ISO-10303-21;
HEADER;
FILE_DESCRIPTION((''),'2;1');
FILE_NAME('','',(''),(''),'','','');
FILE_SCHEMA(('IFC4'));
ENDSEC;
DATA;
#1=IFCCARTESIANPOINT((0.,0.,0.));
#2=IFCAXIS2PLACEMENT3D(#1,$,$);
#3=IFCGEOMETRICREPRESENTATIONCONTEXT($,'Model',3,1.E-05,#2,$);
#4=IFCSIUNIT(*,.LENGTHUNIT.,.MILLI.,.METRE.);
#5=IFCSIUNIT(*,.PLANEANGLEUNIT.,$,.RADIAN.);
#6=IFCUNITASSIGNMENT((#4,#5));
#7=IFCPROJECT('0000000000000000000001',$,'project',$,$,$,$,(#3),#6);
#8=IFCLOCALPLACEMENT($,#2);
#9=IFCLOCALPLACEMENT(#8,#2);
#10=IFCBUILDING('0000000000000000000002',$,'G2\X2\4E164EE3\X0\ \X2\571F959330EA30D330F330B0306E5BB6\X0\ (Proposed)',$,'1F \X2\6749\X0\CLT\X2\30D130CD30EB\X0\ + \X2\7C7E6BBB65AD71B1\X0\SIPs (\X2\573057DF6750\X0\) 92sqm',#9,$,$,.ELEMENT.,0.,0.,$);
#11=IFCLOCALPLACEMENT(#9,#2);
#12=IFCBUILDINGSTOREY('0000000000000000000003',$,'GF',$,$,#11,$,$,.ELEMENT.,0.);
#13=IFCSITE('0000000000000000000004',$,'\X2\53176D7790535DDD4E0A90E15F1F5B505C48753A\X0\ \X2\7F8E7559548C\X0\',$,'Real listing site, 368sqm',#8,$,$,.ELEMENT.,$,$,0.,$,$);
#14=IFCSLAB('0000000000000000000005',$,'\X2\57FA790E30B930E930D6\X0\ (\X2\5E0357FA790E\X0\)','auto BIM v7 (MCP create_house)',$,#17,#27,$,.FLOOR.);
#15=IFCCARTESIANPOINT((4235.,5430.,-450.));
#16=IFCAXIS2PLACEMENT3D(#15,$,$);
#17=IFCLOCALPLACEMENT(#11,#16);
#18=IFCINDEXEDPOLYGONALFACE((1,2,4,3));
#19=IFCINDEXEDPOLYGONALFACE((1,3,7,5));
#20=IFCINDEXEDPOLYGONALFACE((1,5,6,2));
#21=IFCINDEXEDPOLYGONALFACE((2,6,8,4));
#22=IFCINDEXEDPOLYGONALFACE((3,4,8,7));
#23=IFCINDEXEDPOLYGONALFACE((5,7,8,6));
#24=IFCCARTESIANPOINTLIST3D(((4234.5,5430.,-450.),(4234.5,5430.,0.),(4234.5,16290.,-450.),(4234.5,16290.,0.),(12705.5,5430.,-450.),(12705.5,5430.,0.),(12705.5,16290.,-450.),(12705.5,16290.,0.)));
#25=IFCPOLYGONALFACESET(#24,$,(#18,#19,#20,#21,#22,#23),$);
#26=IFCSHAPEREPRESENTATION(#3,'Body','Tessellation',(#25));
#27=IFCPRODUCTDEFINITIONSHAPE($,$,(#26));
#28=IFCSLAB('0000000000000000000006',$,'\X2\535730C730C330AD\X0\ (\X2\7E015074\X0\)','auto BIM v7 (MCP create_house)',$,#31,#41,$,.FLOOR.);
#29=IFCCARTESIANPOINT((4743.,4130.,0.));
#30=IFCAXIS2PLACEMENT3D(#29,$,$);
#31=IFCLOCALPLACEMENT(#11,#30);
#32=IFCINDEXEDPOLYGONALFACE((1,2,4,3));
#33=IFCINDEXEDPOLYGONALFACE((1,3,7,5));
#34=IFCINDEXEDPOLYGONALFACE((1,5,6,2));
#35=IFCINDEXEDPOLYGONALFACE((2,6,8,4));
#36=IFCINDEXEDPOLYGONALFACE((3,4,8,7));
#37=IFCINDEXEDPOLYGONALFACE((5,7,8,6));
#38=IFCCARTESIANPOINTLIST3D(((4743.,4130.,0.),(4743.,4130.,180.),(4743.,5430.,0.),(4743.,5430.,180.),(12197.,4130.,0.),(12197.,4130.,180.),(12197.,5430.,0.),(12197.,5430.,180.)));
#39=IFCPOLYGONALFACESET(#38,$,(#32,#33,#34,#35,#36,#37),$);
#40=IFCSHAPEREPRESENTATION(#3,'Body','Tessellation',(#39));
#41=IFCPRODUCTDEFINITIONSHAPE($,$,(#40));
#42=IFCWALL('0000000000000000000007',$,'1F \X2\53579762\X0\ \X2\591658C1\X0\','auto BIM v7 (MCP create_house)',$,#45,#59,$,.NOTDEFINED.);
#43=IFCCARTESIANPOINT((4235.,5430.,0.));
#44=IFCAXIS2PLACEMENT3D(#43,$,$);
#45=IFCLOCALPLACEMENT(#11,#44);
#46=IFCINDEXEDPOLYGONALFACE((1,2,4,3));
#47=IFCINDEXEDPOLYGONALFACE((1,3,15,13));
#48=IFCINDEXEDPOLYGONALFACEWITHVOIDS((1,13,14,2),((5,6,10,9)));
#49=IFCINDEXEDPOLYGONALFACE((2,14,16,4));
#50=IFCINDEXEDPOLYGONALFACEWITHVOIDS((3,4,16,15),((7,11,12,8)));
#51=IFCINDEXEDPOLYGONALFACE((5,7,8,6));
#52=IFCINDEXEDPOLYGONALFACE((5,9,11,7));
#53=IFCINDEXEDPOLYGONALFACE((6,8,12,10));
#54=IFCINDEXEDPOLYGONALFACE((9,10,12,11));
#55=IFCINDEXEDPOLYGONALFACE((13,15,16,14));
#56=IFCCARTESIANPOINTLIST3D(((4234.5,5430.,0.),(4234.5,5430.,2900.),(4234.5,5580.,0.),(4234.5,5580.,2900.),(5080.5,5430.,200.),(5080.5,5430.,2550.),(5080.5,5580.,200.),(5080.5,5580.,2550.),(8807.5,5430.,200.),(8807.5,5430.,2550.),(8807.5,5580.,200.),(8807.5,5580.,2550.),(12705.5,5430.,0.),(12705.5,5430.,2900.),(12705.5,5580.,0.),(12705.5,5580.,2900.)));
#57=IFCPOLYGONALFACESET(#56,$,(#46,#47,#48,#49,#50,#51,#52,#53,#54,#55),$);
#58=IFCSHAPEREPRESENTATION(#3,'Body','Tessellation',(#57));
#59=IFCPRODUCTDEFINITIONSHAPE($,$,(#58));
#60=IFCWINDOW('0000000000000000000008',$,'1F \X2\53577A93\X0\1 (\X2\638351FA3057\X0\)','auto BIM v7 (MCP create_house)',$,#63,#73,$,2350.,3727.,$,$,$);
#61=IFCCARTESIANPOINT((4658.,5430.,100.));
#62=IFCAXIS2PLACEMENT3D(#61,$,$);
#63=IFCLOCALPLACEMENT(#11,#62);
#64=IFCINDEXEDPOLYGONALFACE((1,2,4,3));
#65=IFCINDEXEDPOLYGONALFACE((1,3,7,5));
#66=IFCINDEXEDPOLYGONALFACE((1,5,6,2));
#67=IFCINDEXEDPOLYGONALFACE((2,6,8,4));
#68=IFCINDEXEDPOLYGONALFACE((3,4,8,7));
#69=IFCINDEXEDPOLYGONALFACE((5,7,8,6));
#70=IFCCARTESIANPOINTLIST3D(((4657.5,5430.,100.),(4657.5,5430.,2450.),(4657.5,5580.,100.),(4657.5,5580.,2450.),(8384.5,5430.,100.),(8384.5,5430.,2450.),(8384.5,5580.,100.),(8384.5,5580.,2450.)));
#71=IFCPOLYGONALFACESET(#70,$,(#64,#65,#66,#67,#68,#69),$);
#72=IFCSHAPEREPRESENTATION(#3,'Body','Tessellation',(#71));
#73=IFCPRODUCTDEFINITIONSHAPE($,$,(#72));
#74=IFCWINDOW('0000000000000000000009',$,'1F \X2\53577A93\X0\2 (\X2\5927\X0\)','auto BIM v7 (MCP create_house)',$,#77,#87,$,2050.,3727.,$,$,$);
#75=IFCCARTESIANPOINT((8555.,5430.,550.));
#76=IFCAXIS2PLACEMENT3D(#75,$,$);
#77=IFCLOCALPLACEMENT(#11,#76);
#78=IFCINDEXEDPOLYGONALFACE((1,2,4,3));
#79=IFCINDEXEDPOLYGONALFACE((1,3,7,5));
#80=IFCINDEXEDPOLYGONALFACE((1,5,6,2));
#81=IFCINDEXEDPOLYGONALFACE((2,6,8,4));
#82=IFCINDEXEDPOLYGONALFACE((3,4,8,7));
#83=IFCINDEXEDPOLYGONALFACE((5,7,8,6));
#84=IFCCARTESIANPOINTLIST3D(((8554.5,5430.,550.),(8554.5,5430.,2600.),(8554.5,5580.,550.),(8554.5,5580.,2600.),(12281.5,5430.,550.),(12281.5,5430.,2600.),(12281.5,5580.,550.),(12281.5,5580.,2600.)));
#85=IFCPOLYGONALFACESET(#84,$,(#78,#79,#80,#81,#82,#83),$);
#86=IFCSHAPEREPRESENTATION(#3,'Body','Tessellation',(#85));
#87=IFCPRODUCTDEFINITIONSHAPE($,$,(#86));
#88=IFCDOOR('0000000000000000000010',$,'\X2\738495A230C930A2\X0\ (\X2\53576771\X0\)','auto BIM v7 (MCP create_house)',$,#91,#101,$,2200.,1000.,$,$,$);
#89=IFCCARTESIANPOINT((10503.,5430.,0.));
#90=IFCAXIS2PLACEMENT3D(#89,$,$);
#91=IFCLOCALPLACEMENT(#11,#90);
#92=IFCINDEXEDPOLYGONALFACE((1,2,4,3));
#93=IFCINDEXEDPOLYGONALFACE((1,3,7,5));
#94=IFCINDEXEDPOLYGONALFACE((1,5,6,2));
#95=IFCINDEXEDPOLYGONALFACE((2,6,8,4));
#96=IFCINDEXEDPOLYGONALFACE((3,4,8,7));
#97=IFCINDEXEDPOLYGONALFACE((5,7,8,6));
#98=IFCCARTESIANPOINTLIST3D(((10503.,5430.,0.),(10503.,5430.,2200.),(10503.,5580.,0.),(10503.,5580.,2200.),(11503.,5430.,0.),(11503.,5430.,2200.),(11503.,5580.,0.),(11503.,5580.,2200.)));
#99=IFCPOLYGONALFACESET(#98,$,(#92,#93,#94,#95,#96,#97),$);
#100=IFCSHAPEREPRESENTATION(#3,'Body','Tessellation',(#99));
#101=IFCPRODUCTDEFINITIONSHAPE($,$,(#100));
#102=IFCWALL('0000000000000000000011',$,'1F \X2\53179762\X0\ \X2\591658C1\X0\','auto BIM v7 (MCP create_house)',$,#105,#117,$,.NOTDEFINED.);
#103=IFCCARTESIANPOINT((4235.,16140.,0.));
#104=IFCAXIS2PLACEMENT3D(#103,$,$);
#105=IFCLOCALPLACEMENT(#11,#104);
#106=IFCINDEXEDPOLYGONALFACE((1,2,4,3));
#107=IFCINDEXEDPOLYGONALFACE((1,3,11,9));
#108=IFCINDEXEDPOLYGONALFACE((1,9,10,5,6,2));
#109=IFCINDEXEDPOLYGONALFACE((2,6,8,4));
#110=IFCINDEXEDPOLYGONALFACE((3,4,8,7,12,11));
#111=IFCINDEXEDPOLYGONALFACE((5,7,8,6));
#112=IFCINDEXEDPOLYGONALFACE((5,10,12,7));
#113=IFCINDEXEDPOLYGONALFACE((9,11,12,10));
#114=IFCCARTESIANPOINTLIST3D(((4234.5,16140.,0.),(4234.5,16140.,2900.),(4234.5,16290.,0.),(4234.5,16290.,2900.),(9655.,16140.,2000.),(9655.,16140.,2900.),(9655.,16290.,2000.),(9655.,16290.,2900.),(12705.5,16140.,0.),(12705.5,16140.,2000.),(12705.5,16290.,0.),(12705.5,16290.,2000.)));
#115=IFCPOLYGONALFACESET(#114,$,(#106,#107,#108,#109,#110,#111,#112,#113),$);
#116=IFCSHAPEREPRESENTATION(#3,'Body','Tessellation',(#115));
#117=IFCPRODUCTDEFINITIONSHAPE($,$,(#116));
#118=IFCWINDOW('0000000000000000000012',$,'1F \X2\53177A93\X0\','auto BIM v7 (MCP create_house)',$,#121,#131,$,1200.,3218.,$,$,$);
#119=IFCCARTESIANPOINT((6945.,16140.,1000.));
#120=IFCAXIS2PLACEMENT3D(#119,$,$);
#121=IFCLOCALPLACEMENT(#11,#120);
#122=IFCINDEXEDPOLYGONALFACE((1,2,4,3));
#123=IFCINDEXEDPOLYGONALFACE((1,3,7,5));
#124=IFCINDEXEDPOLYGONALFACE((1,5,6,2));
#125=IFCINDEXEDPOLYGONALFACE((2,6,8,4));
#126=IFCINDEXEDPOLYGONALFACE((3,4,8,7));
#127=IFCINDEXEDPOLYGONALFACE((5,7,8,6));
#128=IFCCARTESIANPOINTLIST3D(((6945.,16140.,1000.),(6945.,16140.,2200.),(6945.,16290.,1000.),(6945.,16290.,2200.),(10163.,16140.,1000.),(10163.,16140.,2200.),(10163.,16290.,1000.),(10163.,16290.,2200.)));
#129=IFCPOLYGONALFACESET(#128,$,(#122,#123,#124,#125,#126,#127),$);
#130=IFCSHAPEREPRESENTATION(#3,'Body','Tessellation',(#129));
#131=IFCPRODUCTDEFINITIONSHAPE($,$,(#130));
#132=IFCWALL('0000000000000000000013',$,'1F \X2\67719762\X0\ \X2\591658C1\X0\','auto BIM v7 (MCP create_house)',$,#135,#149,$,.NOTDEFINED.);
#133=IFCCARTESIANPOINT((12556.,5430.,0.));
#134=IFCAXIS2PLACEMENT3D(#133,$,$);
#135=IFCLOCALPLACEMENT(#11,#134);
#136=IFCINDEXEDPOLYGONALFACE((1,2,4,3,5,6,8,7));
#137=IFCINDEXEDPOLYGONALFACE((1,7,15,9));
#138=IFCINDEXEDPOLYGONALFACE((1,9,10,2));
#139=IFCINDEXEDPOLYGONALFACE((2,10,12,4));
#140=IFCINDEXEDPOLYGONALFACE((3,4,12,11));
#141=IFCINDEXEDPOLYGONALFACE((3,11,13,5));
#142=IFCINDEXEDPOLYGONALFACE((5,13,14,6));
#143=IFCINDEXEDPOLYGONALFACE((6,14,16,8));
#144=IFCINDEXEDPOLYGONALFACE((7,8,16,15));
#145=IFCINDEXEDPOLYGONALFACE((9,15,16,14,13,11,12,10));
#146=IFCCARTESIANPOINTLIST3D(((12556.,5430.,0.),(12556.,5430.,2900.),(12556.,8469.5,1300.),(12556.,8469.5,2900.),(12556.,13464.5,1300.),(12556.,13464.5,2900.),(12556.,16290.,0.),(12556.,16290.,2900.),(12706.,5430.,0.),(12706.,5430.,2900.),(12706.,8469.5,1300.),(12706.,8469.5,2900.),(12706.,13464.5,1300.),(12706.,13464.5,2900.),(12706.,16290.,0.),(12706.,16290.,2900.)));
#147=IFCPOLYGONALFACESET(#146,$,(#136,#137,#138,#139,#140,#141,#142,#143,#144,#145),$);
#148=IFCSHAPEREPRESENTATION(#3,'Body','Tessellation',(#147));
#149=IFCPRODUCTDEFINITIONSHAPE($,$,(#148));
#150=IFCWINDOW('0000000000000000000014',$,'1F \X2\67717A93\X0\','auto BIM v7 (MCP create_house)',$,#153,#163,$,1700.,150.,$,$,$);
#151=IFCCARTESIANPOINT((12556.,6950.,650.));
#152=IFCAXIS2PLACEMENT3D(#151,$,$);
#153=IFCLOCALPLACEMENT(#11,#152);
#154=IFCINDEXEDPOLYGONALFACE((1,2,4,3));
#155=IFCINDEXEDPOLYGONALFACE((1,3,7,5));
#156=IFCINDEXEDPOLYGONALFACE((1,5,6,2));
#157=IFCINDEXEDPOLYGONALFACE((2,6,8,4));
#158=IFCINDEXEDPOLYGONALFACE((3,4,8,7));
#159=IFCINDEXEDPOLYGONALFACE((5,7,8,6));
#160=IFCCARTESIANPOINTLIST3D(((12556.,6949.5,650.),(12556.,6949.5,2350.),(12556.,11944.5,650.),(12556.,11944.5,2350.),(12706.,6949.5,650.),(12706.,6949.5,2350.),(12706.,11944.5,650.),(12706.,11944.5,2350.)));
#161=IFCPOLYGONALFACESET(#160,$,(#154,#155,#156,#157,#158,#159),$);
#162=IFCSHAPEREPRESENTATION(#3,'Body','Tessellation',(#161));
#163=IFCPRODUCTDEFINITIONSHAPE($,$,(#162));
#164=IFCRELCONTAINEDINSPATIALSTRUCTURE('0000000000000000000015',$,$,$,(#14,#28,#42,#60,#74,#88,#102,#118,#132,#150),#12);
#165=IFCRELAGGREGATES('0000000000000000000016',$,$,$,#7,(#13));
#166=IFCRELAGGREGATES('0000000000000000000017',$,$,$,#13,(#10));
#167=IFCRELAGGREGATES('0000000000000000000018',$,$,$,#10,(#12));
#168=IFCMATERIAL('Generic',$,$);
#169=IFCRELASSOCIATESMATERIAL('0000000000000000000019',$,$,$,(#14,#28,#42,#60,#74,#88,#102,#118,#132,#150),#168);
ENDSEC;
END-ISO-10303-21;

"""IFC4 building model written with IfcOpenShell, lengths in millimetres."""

from ifc_helpers import new_model, si_unit, frame, frame_2d, origin, place, context, project, spatial, rectangle, extrude, material, element, fill, save


model = new_model("IFC4")

# Units and contexts
model_context = context("Model", 3, precision=1e-05, world=origin())
ifc_project = project(units=[si_unit("LENGTHUNIT", "METRE", prefix="MILLI"), si_unit("PLANEANGLEUNIT", "RADIAN")], contexts=[model_context])

# Site, building, storey
site_placement = place(None, origin())
site = spatial("IfcSite", under=ifc_project, at=site_placement, Name="北海道川上郡弟子屈町 美留和", ObjectType="Real listing site, 368sqm", CompositionType="ELEMENT", RefElevation=0.0)
building_placement = place(site_placement, origin())
building = spatial("IfcBuilding", under=site, at=building_placement, Name="G2世代 土間リビングの家 (Proposed)", ObjectType="1F 杉CLTパネル + 籾殻断熱SIPs (地域材) 92sqm", CompositionType="ELEMENT", ElevationOfRefHeight=0.0, ElevationOfTerrain=0.0)
storey_placement = place(building_placement, origin())
storey = spatial("IfcBuildingStorey", under=building, at=storey_placement, Name="GF", CompositionType="ELEMENT", Elevation=0.0)

# Slabs
ifc_material = material(Name="Generic")
slab_1_placement = place(storey_placement, frame((4235.0, 5430.0, -450.0)))
element("IfcSlab", 1, at=slab_1_placement, inside=storey, material=ifc_material, Name="基礎スラブ (布基礎)", Description="auto BIM v7 (MCP create_house)", PredefinedType="FLOOR", context=model_context, shape_type="SweptSolid", body=[
    extrude(rectangle(XDim=8471.0, YDim=10860.0, at=frame_2d((4235.0, 5430.0))), frame((4235.0, 5430.0, -450.0)), (0.0, 0.0, 1.0), 450.0),
])
slab_2_placement = place(storey_placement, frame((4743.0, 4130.0, 0.0)))
element("IfcSlab", 2, at=slab_2_placement, inside=storey, material=ifc_material, Name="南デッキ (縁側)", Description="auto BIM v7 (MCP create_house)", PredefinedType="FLOOR", context=model_context, shape_type="SweptSolid", body=[
    extrude(rectangle(XDim=7454.0, YDim=1300.0, at=frame_2d((3727.0, 650.0))), frame((4743.0, 4130.0, 0.0)), (0.0, 0.0, 1.0), 180.0),
])

# Wall, openings, windows, door
wall_1_placement = place(storey_placement, frame((4235.0, 5430.0, 0.0)))
wall_1 = element("IfcWall", 3, at=wall_1_placement, inside=storey, material=ifc_material, Name="1F 南面 外壁", Description="auto BIM v7 (MCP create_house)", PredefinedType="NOTDEFINED", context=model_context, shape_type="SweptSolid", body=[
    extrude(rectangle(XDim=8471.0, YDim=150.0, at=frame_2d((4235.0, 75.0))), frame((4235.0, 5430.0, 0.0)), (0.0, 0.0, 1.0), 2900.0),
])
opening_1_placement = place(storey_placement, frame((4658.0, 5430.0, 100.0)))
opening_1 = element("IfcOpeningElement", 4, at=opening_1_placement, cuts=wall_1, PredefinedType="NOTDEFINED", context=model_context, shape_type="SweptSolid", body=[
    extrude(rectangle(XDim=3727.0, YDim=150.0, at=frame_2d((1863.0, 75.0))), frame((4658.0, 5430.0, 100.0)), (0.0, 0.0, 1.0), 2350.0),
])
opening_2_placement = place(storey_placement, frame((8555.0, 5430.0, 550.0)))
opening_2 = element("IfcOpeningElement", 5, at=opening_2_placement, cuts=wall_1, PredefinedType="NOTDEFINED", context=model_context, shape_type="SweptSolid", body=[
    extrude(rectangle(XDim=3727.0, YDim=150.0, at=frame_2d((1863.0, 75.0))), frame((8555.0, 5430.0, 550.0)), (0.0, 0.0, 1.0), 2050.0),
])
opening_3_placement = place(storey_placement, frame((10503.0, 5430.0, 0.0)))
opening_3 = element("IfcOpeningElement", 6, at=opening_3_placement, cuts=wall_1, PredefinedType="NOTDEFINED", context=model_context, shape_type="SweptSolid", body=[
    extrude(rectangle(XDim=1000.0, YDim=150.0, at=frame_2d((500.0, 75.0))), frame((10503.0, 5430.0, 0.0)), (0.0, 0.0, 1.0), 2200.0),
])
window_1_placement = place(storey_placement, frame((4658.0, 5430.0, 100.0)))
window_1 = element("IfcWindow", 7, at=window_1_placement, inside=storey, material=ifc_material, Name="1F 南窓1 (掃出し)", Description="auto BIM v7 (MCP create_house)", OverallHeight=2350.0, OverallWidth=3727.0, context=model_context, shape_type="SweptSolid", body=[
    extrude(rectangle(XDim=3727.0, YDim=150.0, at=frame_2d((1863.0, 75.0))), frame((4658.0, 5430.0, 100.0)), (0.0, 0.0, 1.0), 2350.0),
])
fill(opening_1, window_1)
window_2_placement = place(storey_placement, frame((8555.0, 5430.0, 550.0)))
window_2 = element("IfcWindow", 8, at=window_2_placement, inside=storey, material=ifc_material, Name="1F 南窓2 (大)", Description="auto BIM v7 (MCP create_house)", OverallHeight=2050.0, OverallWidth=3727.0, context=model_context, shape_type="SweptSolid", body=[
    extrude(rectangle(XDim=3727.0, YDim=150.0, at=frame_2d((1863.0, 75.0))), frame((8555.0, 5430.0, 550.0)), (0.0, 0.0, 1.0), 2050.0),
])
fill(opening_2, window_2)
door_placement = place(storey_placement, frame((10503.0, 5430.0, 0.0)))
door = element("IfcDoor", 9, at=door_placement, inside=storey, material=ifc_material, Name="玄関ドア (南東)", Description="auto BIM v7 (MCP create_house)", OverallHeight=2200.0, OverallWidth=1000.0, context=model_context, shape_type="SweptSolid", body=[
    extrude(rectangle(XDim=1000.0, YDim=150.0, at=frame_2d((500.0, 75.0))), frame((10503.0, 5430.0, 0.0)), (0.0, 0.0, 1.0), 2200.0),
])
fill(opening_3, door)

# Walls, openings, windows
wall_2_placement = place(storey_placement, frame((4235.0, 16140.0, 0.0)))
wall_2 = element("IfcWall", 10, at=wall_2_placement, inside=storey, material=ifc_material, Name="1F 北面 外壁", Description="auto BIM v7 (MCP create_house)", PredefinedType="NOTDEFINED", context=model_context, shape_type="SweptSolid", body=[
    extrude(rectangle(XDim=8471.0, YDim=150.0, at=frame_2d((4235.0, 75.0))), frame((4235.0, 16140.0, 0.0)), (0.0, 0.0, 1.0), 2900.0),
])
opening_4_placement = place(storey_placement, frame((6945.0, 16140.0, 1000.0)))
opening_4 = element("IfcOpeningElement", 11, at=opening_4_placement, cuts=wall_2, PredefinedType="NOTDEFINED", context=model_context, shape_type="SweptSolid", body=[
    extrude(rectangle(XDim=3218.0, YDim=150.0, at=frame_2d((1609.0, 75.0))), frame((6945.0, 16140.0, 1000.0)), (0.0, 0.0, 1.0), 1200.0),
])
window_3_placement = place(storey_placement, frame((6945.0, 16140.0, 1000.0)))
window_3 = element("IfcWindow", 12, at=window_3_placement, inside=storey, material=ifc_material, Name="1F 北窓", Description="auto BIM v7 (MCP create_house)", OverallHeight=1200.0, OverallWidth=3218.0, context=model_context, shape_type="SweptSolid", body=[
    extrude(rectangle(XDim=3218.0, YDim=150.0, at=frame_2d((1609.0, 75.0))), frame((6945.0, 16140.0, 1000.0)), (0.0, 0.0, 1.0), 1200.0),
])
fill(opening_4, window_3)
wall_3_placement = place(storey_placement, frame((12556.0, 5430.0, 0.0)))
wall_3 = element("IfcWall", 13, at=wall_3_placement, inside=storey, material=ifc_material, Name="1F 東面 外壁", Description="auto BIM v7 (MCP create_house)", PredefinedType="NOTDEFINED", context=model_context, shape_type="SweptSolid", body=[
    extrude(rectangle(XDim=150.0, YDim=10860.0, at=frame_2d((75.0, 5430.0))), frame((12556.0, 5430.0, 0.0)), (0.0, 0.0, 1.0), 2900.0),
])
opening_5_placement = place(storey_placement, frame((12556.0, 6950.0, 650.0)))
opening_5 = element("IfcOpeningElement", 14, at=opening_5_placement, cuts=wall_3, PredefinedType="NOTDEFINED", context=model_context, shape_type="SweptSolid", body=[
    extrude(rectangle(XDim=150.0, YDim=4995.0, at=frame_2d((75.0, 2497.0))), frame((12556.0, 6950.0, 650.0)), (0.0, 0.0, 1.0), 1700.0),
])
window_4_placement = place(storey_placement, frame((12556.0, 6950.0, 650.0)))
window_4 = element("IfcWindow", 15, at=window_4_placement, inside=storey, material=ifc_material, Name="1F 東窓", Description="auto BIM v7 (MCP create_house)", OverallHeight=1700.0, OverallWidth=150.0, context=model_context, shape_type="SweptSolid", body=[
    extrude(rectangle(XDim=150.0, YDim=4995.0, at=frame_2d((75.0, 2497.0))), frame((12556.0, 6950.0, 650.0)), (0.0, 0.0, 1.0), 1700.0),
])
fill(opening_5, window_4)

save(model, "model.ifc")
